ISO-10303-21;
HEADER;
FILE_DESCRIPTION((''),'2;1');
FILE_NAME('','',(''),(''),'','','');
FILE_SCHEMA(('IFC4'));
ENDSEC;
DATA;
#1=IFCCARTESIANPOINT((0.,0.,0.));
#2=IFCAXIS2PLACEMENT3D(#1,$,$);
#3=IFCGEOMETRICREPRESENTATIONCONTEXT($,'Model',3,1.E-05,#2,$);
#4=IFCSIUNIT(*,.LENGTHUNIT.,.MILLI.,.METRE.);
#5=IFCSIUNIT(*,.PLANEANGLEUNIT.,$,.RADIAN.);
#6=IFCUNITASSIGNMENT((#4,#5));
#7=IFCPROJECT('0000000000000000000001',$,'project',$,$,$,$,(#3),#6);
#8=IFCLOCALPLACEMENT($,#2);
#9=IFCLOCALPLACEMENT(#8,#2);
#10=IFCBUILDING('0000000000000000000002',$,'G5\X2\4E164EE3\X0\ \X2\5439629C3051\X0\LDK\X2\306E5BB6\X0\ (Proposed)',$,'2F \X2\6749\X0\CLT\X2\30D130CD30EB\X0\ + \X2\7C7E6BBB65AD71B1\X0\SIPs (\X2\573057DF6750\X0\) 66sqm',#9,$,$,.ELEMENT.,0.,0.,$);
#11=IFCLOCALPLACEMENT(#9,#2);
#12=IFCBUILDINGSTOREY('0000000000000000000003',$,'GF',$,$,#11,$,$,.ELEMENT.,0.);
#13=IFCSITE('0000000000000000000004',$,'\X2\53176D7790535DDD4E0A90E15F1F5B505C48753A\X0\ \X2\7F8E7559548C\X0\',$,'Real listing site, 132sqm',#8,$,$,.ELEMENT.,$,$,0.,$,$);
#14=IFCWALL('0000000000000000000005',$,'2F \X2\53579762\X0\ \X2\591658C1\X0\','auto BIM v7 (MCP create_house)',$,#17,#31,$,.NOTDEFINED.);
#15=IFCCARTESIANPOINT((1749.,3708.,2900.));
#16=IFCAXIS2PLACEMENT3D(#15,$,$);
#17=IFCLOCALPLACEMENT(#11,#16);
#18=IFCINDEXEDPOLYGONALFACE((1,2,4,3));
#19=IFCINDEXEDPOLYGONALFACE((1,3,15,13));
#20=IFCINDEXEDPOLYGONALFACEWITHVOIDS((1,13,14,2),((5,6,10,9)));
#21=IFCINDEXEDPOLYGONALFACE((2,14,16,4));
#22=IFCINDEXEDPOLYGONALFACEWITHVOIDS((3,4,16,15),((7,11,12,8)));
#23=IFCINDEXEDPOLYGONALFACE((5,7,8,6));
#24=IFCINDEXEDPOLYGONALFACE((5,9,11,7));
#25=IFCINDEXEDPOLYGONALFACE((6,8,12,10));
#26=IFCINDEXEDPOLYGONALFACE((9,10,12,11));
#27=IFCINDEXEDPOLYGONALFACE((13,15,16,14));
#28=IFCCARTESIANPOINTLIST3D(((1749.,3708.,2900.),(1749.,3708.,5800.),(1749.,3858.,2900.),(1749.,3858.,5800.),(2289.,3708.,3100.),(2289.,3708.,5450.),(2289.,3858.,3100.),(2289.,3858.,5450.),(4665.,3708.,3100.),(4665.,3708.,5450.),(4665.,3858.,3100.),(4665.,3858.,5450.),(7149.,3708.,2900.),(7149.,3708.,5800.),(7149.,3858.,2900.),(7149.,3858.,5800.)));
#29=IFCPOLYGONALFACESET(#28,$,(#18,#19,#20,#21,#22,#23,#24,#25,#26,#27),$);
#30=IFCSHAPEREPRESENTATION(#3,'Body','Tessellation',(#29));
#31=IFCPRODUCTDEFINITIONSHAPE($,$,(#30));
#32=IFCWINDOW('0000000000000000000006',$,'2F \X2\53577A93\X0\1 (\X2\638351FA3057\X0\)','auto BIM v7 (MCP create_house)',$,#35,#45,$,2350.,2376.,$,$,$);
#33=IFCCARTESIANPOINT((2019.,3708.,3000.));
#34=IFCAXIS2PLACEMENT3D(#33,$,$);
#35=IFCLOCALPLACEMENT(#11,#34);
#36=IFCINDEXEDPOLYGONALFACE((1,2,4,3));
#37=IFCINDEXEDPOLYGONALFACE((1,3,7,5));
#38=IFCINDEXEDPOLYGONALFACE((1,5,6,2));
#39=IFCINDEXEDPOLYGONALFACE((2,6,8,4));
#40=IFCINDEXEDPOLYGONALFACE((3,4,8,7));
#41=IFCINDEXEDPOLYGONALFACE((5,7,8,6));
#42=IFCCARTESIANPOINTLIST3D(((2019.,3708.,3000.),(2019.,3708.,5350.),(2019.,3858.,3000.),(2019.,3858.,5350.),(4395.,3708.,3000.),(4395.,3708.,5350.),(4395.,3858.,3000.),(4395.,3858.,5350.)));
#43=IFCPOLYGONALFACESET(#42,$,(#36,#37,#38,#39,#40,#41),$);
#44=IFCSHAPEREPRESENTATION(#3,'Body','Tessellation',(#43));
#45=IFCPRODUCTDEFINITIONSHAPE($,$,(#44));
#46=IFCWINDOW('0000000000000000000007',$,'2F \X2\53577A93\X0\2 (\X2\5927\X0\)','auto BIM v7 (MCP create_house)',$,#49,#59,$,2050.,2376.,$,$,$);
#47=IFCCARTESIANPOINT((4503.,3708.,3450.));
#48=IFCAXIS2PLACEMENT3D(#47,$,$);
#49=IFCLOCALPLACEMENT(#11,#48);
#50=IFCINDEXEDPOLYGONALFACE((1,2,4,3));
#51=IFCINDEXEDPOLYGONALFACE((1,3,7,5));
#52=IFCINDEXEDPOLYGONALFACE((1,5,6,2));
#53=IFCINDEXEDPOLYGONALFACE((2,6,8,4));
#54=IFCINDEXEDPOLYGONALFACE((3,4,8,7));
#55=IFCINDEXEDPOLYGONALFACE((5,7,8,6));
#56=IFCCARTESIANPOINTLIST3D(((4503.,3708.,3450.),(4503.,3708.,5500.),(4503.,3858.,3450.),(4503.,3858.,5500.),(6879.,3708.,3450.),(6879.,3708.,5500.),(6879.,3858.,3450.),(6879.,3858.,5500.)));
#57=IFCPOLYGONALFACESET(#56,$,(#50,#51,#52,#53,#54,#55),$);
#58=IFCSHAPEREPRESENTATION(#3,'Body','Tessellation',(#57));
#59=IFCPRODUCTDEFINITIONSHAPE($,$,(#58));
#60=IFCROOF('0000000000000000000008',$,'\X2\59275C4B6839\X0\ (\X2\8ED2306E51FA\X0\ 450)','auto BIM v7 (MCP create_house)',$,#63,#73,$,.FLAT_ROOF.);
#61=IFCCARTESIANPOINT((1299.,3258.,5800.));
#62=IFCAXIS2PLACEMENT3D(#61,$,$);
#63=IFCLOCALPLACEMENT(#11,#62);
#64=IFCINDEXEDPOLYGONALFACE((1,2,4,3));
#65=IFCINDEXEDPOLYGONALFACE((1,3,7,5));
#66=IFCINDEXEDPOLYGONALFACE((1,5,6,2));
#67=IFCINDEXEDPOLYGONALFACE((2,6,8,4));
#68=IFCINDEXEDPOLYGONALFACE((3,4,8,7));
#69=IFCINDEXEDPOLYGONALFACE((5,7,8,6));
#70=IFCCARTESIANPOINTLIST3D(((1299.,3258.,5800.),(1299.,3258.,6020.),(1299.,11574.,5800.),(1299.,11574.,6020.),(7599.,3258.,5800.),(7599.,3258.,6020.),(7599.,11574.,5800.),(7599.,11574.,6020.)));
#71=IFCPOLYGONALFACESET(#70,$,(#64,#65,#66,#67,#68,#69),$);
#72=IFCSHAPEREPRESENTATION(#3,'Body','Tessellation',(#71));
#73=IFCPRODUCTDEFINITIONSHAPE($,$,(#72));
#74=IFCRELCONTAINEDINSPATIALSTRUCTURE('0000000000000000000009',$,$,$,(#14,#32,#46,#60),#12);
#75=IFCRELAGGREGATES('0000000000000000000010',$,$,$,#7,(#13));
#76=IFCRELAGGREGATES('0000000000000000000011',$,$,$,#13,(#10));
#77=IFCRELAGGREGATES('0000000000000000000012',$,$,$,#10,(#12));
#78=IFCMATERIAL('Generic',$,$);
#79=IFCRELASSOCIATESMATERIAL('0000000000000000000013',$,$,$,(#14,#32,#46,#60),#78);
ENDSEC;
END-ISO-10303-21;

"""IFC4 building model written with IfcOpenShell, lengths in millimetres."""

from ifc_helpers import new_model, si_unit, frame, frame_2d, origin, place, context, project, spatial, rectangle, extrude, material, element, fill, save


model = new_model("IFC4")

# Units and contexts
model_context = context("Model", 3, precision=1e-05, world=origin())
ifc_project = project(units=[si_unit("LENGTHUNIT", "METRE", prefix="MILLI"), si_unit("PLANEANGLEUNIT", "RADIAN")], contexts=[model_context])

# Site, building, storey
site_placement = place(None, origin())
site = spatial("IfcSite", under=ifc_project, at=site_placement, Name="北海道川上郡弟子屈町 美留和", ObjectType="Real listing site, 132sqm", CompositionType="ELEMENT", RefElevation=0.0)
building_placement = place(site_placement, origin())
building = spatial("IfcBuilding", under=site, at=building_placement, Name="G5世代 吹抜けLDKの家 (Proposed)", ObjectType="2F 杉CLTパネル + 籾殻断熱SIPs (地域材) 66sqm", CompositionType="ELEMENT", ElevationOfRefHeight=0.0, ElevationOfTerrain=0.0)
storey_placement = place(building_placement, origin())
storey = spatial("IfcBuildingStorey", under=building, at=storey_placement, Name="GF", CompositionType="ELEMENT", Elevation=0.0)

# Shared definitions
ifc_material = material(Name="Generic")

# Wall, openings, windows
wall_1_placement = place(storey_placement, frame((1749.0, 3708.0, 2900.0)))
wall_1 = element("IfcWall", 1, at=wall_1_placement, inside=storey, material=ifc_material, Name="2F 南面 外壁", Description="auto BIM v7 (MCP create_house)", PredefinedType="NOTDEFINED", context=model_context, shape_type="SweptSolid", body=[
    extrude(rectangle(XDim=5400.0, YDim=150.0, at=frame_2d((2700.0, 75.0))), frame((1749.0, 3708.0, 2900.0)), (0.0, 0.0, 1.0), 2900.0),
])
opening_1_placement = place(storey_placement, frame((2019.0, 3708.0, 3000.0)))
opening_1 = element("IfcOpeningElement", 2, at=opening_1_placement, cuts=wall_1, PredefinedType="NOTDEFINED", context=model_context, shape_type="SweptSolid", body=[
    extrude(rectangle(XDim=2376.0, YDim=150.0, at=frame_2d((1188.0, 75.0))), frame((2019.0, 3708.0, 3000.0)), (0.0, 0.0, 1.0), 2350.0),
])
opening_2_placement = place(storey_placement, frame((4503.0, 3708.0, 3450.0)))
opening_2 = element("IfcOpeningElement", 3, at=opening_2_placement, cuts=wall_1, PredefinedType="NOTDEFINED", context=model_context, shape_type="SweptSolid", body=[
    extrude(rectangle(XDim=2376.0, YDim=150.0, at=frame_2d((1188.0, 75.0))), frame((4503.0, 3708.0, 3450.0)), (0.0, 0.0, 1.0), 2050.0),
])
window_1_placement = place(storey_placement, frame((2019.0, 3708.0, 3000.0)))
window_1 = element("IfcWindow", 4, at=window_1_placement, inside=storey, material=ifc_material, Name="2F 南窓1 (掃出し)", Description="auto BIM v7 (MCP create_house)", OverallHeight=2350.0, OverallWidth=2376.0, context=model_context, shape_type="SweptSolid", body=[
    extrude(rectangle(XDim=2376.0, YDim=150.0, at=frame_2d((1188.0, 75.0))), frame((2019.0, 3708.0, 3000.0)), (0.0, 0.0, 1.0), 2350.0),
])
fill(opening_1, window_1)
window_2_placement = place(storey_placement, frame((4503.0, 3708.0, 3450.0)))
window_2 = element("IfcWindow", 5, at=window_2_placement, inside=storey, material=ifc_material, Name="2F 南窓2 (大)", Description="auto BIM v7 (MCP create_house)", OverallHeight=2050.0, OverallWidth=2376.0, context=model_context, shape_type="SweptSolid", body=[
    extrude(rectangle(XDim=2376.0, YDim=150.0, at=frame_2d((1188.0, 75.0))), frame((4503.0, 3708.0, 3450.0)), (0.0, 0.0, 1.0), 2050.0),
])
fill(opening_2, window_2)

# Roof
roof_placement = place(storey_placement, frame((1299.0, 3258.0, 5800.0)))
element("IfcRoof", 6, at=roof_placement, inside=storey, material=ifc_material, Name="大屋根 (軒の出 450)", Description="auto BIM v7 (MCP create_house)", PredefinedType="FLAT_ROOF", context=model_context, shape_type="SweptSolid", body=[
    extrude(rectangle(XDim=6300.0, YDim=8316.0, at=frame_2d((3150.0, 4158.0))), frame((1299.0, 3258.0, 5800.0)), (0.0, 0.0, 1.0), 220.0),
])

save(model, "model.ifc")
